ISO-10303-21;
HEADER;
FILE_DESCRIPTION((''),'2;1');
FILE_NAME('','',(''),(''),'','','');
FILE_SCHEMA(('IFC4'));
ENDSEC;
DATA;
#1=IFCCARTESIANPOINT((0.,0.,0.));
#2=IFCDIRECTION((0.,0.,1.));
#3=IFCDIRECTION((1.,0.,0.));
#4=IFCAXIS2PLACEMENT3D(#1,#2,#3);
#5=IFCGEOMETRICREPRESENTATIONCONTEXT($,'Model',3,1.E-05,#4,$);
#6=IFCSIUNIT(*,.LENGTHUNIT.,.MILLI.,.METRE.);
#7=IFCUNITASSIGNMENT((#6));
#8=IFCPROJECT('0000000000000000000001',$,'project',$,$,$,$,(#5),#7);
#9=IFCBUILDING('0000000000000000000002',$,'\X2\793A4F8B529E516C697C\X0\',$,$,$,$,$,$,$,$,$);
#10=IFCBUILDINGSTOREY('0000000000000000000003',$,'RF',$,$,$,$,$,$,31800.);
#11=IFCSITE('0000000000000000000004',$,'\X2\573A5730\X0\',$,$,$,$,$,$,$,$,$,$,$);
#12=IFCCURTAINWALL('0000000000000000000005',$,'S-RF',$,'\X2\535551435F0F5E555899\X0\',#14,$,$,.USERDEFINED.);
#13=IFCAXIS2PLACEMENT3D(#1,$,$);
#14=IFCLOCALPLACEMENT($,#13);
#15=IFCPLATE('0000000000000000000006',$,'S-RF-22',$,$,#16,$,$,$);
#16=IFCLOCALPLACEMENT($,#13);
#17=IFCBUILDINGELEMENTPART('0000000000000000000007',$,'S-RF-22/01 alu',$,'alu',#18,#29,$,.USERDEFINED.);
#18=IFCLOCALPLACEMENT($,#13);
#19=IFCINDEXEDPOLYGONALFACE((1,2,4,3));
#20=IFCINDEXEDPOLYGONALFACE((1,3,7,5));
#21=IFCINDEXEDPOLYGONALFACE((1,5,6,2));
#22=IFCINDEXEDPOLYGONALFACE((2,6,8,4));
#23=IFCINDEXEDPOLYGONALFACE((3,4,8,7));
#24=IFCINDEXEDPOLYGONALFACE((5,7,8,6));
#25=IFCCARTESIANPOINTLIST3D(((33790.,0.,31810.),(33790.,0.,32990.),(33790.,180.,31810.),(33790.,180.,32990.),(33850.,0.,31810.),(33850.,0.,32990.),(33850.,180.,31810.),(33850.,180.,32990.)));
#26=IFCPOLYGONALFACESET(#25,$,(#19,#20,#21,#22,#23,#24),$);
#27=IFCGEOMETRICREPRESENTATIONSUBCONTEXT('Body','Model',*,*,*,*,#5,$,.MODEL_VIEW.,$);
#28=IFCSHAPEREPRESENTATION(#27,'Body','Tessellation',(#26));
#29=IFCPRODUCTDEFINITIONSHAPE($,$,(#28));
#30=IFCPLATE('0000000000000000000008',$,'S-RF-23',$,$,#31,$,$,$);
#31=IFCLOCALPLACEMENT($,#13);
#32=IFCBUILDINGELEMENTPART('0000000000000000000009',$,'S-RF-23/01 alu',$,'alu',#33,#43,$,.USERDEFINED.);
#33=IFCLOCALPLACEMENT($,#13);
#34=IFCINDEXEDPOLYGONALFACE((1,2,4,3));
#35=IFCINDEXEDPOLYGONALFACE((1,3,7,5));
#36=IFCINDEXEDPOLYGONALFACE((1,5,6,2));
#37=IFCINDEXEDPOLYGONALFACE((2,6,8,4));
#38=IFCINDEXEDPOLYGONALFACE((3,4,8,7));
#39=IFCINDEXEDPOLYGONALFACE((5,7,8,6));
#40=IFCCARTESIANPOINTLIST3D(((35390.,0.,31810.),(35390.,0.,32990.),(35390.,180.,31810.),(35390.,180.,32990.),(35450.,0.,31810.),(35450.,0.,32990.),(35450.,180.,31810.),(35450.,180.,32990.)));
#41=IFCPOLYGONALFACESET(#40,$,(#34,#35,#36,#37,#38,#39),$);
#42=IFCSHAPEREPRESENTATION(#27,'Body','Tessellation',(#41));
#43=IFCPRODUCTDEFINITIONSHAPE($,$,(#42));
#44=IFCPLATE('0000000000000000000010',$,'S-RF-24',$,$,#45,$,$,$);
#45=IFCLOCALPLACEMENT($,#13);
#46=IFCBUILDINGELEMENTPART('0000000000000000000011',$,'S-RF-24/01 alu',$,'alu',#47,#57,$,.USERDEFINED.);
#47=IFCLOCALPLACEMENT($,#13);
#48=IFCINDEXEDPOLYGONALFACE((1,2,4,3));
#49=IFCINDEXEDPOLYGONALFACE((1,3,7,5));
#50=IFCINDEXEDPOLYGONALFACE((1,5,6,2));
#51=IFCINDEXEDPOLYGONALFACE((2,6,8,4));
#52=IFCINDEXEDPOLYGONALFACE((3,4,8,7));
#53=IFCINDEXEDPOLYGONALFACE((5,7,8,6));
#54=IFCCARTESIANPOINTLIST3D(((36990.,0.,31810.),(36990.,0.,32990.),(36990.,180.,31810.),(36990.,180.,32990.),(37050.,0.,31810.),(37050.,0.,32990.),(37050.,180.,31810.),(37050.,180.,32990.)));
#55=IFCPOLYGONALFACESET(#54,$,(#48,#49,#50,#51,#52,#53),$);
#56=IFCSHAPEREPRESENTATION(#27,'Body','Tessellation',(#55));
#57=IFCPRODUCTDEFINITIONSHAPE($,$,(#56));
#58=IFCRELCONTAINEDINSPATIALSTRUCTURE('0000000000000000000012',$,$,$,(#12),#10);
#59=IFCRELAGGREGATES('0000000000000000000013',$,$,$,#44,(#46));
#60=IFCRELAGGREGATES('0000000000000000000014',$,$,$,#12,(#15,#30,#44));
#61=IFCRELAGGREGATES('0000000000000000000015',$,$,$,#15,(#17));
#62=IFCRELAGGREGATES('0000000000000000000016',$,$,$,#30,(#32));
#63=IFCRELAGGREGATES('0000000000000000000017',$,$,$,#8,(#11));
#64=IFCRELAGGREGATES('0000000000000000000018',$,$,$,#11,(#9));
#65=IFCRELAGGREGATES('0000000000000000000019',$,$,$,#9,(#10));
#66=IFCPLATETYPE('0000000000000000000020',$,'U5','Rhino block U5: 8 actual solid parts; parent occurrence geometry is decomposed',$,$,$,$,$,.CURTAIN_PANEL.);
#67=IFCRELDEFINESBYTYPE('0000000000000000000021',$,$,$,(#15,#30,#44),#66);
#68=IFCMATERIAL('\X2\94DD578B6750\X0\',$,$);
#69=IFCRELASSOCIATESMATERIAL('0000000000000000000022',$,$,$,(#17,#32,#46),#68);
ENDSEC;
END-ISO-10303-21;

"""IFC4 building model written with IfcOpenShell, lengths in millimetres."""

from ifc_helpers import new_model, si_unit, frame, frame_2d, origin, origin_with_axes, place, context, subcontext, project, spatial, rectangle, extrude, source, transform, mapped, material, type_object, element, aggregate, save


model = new_model("IFC4")

# Units and contexts
model_context = context("Model", 3, precision=1e-05, world=origin_with_axes())
body_context = subcontext(model_context, "Body", "Model", "MODEL_VIEW")
ifc_project = project(units=[si_unit("LENGTHUNIT", "METRE", prefix="MILLI")], contexts=[model_context])

# Site, building, storey
site = spatial("IfcSite", under=ifc_project, Name="场地")
building = spatial("IfcBuilding", under=site, Name="示例办公楼")
storey = spatial("IfcBuildingStorey", under=building, Name="RF", Elevation=31800.0)

# Curtain wall, plates, building element parts
curtain_wall = element("IfcCurtainWall", 1, inside=storey, Name="S-RF", ObjectType="单元式幕墙", PredefinedType="USERDEFINED")
plate_type = type_object("IfcPlateType", Name="U5", Description="Rhino block U5: 8 actual solid parts; parent occurrence geometry is decomposed", PredefinedType="CURTAIN_PANEL")
plate_1_placement = place(None, frame((33790.0, 0.0, 31810.0), z_axis=(0.0, 0.0, 1.0), x_axis=(1.0, 0.0, 0.0)))
plate_1 = element("IfcPlate", 2, at=plate_1_placement, type_object=plate_type, Name="S-RF-22")
ifc_material_1 = material(Name="铝型材")
shared_shape_1 = source(origin(), body_context, "Body", "SweptSolid", [
    extrude(rectangle(XDim=60.0, YDim=180.0, at=frame_2d((30.0, 90.0))), origin(), (0.0, 0.0, 1.0), 1180.0),
])
building_element_part_1_placement = place(plate_1_placement, origin())
building_element_part_1 = element("IfcBuildingElementPart", 3, at=building_element_part_1_placement, material=ifc_material_1, Name="S-RF-22/01 alu", ObjectType="alu", PredefinedType="USERDEFINED", context=body_context, shape_type="MappedRepresentation", body=[
    mapped(shared_shape_1, transform((0.0, 0.0, 0.0))),
])
plate_2_placement = place(None, frame((35390.0, 0.0, 31810.0), z_axis=(0.0, 0.0, 1.0), x_axis=(1.0, 0.0, 0.0)))
plate_2 = element("IfcPlate", 4, at=plate_2_placement, type_object=plate_type, Name="S-RF-23")
building_element_part_2_placement = place(plate_2_placement, origin())
building_element_part_2 = element("IfcBuildingElementPart", 5, at=building_element_part_2_placement, material=ifc_material_1, Name="S-RF-23/01 alu", ObjectType="alu", PredefinedType="USERDEFINED", context=body_context, shape_type="MappedRepresentation", body=[
    mapped(shared_shape_1, transform((0.0, 0.0, 0.0))),
])
plate_3_placement = place(None, frame((36990.0, 0.0, 31810.0), z_axis=(0.0, 0.0, 1.0), x_axis=(1.0, 0.0, 0.0)))
plate_3 = element("IfcPlate", 6, at=plate_3_placement, type_object=plate_type, Name="S-RF-24")
building_element_part_3_placement = place(plate_3_placement, origin())
building_element_part_3 = element("IfcBuildingElementPart", 7, at=building_element_part_3_placement, material=ifc_material_1, Name="S-RF-24/01 alu", ObjectType="alu", PredefinedType="USERDEFINED", context=body_context, shape_type="MappedRepresentation", body=[
    mapped(shared_shape_1, transform((0.0, 0.0, 0.0))),
])
aggregate(plate_3, [building_element_part_3])
aggregate(curtain_wall, [plate_1, plate_2, plate_3])
aggregate(plate_1, [building_element_part_1])
aggregate(plate_2, [building_element_part_2])

save(model, "model.ifc")
